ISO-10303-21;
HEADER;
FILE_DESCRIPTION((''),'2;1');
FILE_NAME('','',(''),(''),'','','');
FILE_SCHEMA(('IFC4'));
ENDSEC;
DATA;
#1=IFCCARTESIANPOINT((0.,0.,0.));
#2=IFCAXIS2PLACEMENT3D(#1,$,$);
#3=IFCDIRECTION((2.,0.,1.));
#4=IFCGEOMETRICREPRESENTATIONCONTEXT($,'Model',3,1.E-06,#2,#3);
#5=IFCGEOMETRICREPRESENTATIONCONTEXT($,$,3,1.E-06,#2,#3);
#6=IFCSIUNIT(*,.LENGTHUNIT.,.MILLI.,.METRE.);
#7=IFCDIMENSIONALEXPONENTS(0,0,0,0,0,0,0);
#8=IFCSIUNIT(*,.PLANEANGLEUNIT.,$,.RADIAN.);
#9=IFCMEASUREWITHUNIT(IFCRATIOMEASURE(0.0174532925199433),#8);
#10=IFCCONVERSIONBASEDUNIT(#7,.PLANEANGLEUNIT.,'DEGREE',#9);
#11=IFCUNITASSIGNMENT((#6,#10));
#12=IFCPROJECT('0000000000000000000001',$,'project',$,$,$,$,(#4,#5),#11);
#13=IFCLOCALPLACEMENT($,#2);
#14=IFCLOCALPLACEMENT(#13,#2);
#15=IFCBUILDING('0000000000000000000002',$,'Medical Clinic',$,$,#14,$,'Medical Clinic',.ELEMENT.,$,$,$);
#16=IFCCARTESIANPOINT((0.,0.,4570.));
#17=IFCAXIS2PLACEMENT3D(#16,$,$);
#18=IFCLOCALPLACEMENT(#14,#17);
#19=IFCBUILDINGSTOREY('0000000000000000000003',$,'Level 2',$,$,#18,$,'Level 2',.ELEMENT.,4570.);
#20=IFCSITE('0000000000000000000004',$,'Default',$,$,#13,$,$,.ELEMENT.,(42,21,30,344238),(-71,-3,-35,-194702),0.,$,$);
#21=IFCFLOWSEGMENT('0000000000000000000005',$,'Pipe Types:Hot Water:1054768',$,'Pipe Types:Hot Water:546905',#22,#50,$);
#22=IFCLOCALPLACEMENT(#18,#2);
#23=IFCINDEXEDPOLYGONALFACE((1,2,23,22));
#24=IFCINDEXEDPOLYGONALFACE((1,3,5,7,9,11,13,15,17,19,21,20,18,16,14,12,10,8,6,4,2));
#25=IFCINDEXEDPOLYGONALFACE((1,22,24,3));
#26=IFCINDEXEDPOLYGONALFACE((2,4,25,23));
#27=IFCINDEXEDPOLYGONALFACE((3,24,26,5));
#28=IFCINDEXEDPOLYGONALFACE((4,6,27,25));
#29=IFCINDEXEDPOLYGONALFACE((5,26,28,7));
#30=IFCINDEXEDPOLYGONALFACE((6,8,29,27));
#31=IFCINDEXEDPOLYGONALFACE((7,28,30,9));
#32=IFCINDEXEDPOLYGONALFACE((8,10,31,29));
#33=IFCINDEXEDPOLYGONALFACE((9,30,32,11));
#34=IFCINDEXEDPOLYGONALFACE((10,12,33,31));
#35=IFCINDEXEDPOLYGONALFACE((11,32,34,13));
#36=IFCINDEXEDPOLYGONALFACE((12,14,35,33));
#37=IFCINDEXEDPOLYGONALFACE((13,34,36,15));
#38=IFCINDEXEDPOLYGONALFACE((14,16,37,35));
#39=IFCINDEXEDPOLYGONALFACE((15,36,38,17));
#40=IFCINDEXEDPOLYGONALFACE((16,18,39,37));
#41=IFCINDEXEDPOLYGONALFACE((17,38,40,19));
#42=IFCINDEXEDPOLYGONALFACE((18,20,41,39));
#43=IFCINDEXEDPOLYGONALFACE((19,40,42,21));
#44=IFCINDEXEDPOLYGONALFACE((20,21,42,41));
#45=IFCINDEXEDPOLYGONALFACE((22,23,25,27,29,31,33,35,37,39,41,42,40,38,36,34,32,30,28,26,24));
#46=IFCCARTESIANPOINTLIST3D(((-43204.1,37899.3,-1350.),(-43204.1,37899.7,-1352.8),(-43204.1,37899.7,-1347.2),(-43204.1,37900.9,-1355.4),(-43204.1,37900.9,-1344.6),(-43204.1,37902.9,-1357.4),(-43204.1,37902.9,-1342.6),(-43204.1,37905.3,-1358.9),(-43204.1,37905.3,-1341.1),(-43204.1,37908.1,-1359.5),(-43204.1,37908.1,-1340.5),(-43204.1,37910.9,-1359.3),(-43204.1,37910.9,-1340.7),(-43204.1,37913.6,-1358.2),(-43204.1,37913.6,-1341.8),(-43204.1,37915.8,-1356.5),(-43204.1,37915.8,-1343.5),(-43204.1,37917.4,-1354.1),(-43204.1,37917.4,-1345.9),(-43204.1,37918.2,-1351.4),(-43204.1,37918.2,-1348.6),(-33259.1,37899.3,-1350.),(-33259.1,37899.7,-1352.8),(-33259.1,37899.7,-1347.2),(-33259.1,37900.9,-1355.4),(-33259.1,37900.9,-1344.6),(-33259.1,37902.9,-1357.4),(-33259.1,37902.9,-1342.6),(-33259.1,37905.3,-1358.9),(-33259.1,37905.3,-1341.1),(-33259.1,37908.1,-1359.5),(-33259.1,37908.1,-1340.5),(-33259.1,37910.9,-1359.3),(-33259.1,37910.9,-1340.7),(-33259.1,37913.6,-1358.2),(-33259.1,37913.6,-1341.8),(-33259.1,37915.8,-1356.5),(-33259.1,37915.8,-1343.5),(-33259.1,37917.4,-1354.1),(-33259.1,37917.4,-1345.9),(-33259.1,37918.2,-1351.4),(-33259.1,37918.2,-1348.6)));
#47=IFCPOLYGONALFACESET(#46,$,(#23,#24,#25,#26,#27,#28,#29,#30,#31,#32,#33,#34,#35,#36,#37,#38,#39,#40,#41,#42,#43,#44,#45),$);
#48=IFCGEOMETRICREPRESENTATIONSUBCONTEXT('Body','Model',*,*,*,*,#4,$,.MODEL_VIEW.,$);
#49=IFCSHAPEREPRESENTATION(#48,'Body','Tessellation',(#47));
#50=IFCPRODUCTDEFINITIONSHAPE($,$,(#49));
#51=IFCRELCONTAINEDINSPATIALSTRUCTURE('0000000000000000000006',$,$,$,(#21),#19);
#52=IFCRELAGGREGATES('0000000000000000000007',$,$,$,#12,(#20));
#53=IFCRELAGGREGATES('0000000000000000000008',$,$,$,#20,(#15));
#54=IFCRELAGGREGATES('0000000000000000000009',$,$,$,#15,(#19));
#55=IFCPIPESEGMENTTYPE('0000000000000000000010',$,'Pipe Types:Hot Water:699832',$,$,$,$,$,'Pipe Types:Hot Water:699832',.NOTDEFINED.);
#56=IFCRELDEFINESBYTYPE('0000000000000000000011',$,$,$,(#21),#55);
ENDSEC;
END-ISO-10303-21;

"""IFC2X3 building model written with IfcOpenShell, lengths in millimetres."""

from ifc_helpers import new_model, entity, si_unit, converted_unit, direction, frame, origin, origin_2d_with_axis, place, context, subcontext, project, spatial, circle, extrude, type_object, element, save


model = new_model("IFC2X3")

# Units and contexts
model_context = context("Model", 3, precision=1e-06, world=origin(), true_north=direction((2.0, 0.0, 1.0)))
context_of_model = context(None, 3, precision=1e-06, world=origin(), true_north=direction((2.0, 0.0, 1.0)))
body_context = subcontext(model_context, "Body", "Model", "MODEL_VIEW")
ifc_project = project(units=[si_unit("LENGTHUNIT", "METRE", prefix="MILLI"), converted_unit("PLANEANGLEUNIT", "DEGREE", entity("IfcRatioMeasure", 0.0174532925199433), si_unit("PLANEANGLEUNIT", "RADIAN"), dimensions=[0, 0, 0, 0, 0, 0, 0])], contexts=[model_context, context_of_model])

# Site, building, storey
site_placement = place(None, origin())
site = spatial("IfcSite", under=ifc_project, at=site_placement, Name="Default", CompositionType="ELEMENT", RefLatitude=(42, 21, 30, 344238), RefLongitude=(-71, -3, -35, -194702), RefElevation=0.0)
building_placement = place(site_placement, origin())
building = spatial("IfcBuilding", under=site, at=building_placement, Name="Medical Clinic", LongName="Medical Clinic", CompositionType="ELEMENT")
storey_placement = place(building_placement, frame((0.0, 0.0, 4570.0)))
storey = spatial("IfcBuildingStorey", under=building, at=storey_placement, Name="Level 2", LongName="Level 2", CompositionType="ELEMENT", Elevation=4570.0)

# Flow segment
pipe_segment_type_1 = type_object("IfcPipeSegmentType", Name="Pipe Types:Hot Water:699832", ElementType="Pipe Types:Hot Water:699832", PredefinedType="NOTDEFINED")
flow_segment_1_placement = place(storey_placement, origin())
element("IfcFlowSegment", 1, at=flow_segment_1_placement, inside=storey, type_object=pipe_segment_type_1, Name="Pipe Types:Hot Water:1054768", ObjectType="Pipe Types:Hot Water:546905", context=body_context, shape_type="SweptSolid", body=[
    extrude(circle(Radius=9.5, at=origin_2d_with_axis()), frame((-43204.1, 37908.8, -1350.0), z_axis=(1.0, 0.0, 0.0), x_axis=(0.0, -1.0, 0.0)), (0.0, 0.0, 1.0), 9945.0),
])

save(model, "model.ifc")
